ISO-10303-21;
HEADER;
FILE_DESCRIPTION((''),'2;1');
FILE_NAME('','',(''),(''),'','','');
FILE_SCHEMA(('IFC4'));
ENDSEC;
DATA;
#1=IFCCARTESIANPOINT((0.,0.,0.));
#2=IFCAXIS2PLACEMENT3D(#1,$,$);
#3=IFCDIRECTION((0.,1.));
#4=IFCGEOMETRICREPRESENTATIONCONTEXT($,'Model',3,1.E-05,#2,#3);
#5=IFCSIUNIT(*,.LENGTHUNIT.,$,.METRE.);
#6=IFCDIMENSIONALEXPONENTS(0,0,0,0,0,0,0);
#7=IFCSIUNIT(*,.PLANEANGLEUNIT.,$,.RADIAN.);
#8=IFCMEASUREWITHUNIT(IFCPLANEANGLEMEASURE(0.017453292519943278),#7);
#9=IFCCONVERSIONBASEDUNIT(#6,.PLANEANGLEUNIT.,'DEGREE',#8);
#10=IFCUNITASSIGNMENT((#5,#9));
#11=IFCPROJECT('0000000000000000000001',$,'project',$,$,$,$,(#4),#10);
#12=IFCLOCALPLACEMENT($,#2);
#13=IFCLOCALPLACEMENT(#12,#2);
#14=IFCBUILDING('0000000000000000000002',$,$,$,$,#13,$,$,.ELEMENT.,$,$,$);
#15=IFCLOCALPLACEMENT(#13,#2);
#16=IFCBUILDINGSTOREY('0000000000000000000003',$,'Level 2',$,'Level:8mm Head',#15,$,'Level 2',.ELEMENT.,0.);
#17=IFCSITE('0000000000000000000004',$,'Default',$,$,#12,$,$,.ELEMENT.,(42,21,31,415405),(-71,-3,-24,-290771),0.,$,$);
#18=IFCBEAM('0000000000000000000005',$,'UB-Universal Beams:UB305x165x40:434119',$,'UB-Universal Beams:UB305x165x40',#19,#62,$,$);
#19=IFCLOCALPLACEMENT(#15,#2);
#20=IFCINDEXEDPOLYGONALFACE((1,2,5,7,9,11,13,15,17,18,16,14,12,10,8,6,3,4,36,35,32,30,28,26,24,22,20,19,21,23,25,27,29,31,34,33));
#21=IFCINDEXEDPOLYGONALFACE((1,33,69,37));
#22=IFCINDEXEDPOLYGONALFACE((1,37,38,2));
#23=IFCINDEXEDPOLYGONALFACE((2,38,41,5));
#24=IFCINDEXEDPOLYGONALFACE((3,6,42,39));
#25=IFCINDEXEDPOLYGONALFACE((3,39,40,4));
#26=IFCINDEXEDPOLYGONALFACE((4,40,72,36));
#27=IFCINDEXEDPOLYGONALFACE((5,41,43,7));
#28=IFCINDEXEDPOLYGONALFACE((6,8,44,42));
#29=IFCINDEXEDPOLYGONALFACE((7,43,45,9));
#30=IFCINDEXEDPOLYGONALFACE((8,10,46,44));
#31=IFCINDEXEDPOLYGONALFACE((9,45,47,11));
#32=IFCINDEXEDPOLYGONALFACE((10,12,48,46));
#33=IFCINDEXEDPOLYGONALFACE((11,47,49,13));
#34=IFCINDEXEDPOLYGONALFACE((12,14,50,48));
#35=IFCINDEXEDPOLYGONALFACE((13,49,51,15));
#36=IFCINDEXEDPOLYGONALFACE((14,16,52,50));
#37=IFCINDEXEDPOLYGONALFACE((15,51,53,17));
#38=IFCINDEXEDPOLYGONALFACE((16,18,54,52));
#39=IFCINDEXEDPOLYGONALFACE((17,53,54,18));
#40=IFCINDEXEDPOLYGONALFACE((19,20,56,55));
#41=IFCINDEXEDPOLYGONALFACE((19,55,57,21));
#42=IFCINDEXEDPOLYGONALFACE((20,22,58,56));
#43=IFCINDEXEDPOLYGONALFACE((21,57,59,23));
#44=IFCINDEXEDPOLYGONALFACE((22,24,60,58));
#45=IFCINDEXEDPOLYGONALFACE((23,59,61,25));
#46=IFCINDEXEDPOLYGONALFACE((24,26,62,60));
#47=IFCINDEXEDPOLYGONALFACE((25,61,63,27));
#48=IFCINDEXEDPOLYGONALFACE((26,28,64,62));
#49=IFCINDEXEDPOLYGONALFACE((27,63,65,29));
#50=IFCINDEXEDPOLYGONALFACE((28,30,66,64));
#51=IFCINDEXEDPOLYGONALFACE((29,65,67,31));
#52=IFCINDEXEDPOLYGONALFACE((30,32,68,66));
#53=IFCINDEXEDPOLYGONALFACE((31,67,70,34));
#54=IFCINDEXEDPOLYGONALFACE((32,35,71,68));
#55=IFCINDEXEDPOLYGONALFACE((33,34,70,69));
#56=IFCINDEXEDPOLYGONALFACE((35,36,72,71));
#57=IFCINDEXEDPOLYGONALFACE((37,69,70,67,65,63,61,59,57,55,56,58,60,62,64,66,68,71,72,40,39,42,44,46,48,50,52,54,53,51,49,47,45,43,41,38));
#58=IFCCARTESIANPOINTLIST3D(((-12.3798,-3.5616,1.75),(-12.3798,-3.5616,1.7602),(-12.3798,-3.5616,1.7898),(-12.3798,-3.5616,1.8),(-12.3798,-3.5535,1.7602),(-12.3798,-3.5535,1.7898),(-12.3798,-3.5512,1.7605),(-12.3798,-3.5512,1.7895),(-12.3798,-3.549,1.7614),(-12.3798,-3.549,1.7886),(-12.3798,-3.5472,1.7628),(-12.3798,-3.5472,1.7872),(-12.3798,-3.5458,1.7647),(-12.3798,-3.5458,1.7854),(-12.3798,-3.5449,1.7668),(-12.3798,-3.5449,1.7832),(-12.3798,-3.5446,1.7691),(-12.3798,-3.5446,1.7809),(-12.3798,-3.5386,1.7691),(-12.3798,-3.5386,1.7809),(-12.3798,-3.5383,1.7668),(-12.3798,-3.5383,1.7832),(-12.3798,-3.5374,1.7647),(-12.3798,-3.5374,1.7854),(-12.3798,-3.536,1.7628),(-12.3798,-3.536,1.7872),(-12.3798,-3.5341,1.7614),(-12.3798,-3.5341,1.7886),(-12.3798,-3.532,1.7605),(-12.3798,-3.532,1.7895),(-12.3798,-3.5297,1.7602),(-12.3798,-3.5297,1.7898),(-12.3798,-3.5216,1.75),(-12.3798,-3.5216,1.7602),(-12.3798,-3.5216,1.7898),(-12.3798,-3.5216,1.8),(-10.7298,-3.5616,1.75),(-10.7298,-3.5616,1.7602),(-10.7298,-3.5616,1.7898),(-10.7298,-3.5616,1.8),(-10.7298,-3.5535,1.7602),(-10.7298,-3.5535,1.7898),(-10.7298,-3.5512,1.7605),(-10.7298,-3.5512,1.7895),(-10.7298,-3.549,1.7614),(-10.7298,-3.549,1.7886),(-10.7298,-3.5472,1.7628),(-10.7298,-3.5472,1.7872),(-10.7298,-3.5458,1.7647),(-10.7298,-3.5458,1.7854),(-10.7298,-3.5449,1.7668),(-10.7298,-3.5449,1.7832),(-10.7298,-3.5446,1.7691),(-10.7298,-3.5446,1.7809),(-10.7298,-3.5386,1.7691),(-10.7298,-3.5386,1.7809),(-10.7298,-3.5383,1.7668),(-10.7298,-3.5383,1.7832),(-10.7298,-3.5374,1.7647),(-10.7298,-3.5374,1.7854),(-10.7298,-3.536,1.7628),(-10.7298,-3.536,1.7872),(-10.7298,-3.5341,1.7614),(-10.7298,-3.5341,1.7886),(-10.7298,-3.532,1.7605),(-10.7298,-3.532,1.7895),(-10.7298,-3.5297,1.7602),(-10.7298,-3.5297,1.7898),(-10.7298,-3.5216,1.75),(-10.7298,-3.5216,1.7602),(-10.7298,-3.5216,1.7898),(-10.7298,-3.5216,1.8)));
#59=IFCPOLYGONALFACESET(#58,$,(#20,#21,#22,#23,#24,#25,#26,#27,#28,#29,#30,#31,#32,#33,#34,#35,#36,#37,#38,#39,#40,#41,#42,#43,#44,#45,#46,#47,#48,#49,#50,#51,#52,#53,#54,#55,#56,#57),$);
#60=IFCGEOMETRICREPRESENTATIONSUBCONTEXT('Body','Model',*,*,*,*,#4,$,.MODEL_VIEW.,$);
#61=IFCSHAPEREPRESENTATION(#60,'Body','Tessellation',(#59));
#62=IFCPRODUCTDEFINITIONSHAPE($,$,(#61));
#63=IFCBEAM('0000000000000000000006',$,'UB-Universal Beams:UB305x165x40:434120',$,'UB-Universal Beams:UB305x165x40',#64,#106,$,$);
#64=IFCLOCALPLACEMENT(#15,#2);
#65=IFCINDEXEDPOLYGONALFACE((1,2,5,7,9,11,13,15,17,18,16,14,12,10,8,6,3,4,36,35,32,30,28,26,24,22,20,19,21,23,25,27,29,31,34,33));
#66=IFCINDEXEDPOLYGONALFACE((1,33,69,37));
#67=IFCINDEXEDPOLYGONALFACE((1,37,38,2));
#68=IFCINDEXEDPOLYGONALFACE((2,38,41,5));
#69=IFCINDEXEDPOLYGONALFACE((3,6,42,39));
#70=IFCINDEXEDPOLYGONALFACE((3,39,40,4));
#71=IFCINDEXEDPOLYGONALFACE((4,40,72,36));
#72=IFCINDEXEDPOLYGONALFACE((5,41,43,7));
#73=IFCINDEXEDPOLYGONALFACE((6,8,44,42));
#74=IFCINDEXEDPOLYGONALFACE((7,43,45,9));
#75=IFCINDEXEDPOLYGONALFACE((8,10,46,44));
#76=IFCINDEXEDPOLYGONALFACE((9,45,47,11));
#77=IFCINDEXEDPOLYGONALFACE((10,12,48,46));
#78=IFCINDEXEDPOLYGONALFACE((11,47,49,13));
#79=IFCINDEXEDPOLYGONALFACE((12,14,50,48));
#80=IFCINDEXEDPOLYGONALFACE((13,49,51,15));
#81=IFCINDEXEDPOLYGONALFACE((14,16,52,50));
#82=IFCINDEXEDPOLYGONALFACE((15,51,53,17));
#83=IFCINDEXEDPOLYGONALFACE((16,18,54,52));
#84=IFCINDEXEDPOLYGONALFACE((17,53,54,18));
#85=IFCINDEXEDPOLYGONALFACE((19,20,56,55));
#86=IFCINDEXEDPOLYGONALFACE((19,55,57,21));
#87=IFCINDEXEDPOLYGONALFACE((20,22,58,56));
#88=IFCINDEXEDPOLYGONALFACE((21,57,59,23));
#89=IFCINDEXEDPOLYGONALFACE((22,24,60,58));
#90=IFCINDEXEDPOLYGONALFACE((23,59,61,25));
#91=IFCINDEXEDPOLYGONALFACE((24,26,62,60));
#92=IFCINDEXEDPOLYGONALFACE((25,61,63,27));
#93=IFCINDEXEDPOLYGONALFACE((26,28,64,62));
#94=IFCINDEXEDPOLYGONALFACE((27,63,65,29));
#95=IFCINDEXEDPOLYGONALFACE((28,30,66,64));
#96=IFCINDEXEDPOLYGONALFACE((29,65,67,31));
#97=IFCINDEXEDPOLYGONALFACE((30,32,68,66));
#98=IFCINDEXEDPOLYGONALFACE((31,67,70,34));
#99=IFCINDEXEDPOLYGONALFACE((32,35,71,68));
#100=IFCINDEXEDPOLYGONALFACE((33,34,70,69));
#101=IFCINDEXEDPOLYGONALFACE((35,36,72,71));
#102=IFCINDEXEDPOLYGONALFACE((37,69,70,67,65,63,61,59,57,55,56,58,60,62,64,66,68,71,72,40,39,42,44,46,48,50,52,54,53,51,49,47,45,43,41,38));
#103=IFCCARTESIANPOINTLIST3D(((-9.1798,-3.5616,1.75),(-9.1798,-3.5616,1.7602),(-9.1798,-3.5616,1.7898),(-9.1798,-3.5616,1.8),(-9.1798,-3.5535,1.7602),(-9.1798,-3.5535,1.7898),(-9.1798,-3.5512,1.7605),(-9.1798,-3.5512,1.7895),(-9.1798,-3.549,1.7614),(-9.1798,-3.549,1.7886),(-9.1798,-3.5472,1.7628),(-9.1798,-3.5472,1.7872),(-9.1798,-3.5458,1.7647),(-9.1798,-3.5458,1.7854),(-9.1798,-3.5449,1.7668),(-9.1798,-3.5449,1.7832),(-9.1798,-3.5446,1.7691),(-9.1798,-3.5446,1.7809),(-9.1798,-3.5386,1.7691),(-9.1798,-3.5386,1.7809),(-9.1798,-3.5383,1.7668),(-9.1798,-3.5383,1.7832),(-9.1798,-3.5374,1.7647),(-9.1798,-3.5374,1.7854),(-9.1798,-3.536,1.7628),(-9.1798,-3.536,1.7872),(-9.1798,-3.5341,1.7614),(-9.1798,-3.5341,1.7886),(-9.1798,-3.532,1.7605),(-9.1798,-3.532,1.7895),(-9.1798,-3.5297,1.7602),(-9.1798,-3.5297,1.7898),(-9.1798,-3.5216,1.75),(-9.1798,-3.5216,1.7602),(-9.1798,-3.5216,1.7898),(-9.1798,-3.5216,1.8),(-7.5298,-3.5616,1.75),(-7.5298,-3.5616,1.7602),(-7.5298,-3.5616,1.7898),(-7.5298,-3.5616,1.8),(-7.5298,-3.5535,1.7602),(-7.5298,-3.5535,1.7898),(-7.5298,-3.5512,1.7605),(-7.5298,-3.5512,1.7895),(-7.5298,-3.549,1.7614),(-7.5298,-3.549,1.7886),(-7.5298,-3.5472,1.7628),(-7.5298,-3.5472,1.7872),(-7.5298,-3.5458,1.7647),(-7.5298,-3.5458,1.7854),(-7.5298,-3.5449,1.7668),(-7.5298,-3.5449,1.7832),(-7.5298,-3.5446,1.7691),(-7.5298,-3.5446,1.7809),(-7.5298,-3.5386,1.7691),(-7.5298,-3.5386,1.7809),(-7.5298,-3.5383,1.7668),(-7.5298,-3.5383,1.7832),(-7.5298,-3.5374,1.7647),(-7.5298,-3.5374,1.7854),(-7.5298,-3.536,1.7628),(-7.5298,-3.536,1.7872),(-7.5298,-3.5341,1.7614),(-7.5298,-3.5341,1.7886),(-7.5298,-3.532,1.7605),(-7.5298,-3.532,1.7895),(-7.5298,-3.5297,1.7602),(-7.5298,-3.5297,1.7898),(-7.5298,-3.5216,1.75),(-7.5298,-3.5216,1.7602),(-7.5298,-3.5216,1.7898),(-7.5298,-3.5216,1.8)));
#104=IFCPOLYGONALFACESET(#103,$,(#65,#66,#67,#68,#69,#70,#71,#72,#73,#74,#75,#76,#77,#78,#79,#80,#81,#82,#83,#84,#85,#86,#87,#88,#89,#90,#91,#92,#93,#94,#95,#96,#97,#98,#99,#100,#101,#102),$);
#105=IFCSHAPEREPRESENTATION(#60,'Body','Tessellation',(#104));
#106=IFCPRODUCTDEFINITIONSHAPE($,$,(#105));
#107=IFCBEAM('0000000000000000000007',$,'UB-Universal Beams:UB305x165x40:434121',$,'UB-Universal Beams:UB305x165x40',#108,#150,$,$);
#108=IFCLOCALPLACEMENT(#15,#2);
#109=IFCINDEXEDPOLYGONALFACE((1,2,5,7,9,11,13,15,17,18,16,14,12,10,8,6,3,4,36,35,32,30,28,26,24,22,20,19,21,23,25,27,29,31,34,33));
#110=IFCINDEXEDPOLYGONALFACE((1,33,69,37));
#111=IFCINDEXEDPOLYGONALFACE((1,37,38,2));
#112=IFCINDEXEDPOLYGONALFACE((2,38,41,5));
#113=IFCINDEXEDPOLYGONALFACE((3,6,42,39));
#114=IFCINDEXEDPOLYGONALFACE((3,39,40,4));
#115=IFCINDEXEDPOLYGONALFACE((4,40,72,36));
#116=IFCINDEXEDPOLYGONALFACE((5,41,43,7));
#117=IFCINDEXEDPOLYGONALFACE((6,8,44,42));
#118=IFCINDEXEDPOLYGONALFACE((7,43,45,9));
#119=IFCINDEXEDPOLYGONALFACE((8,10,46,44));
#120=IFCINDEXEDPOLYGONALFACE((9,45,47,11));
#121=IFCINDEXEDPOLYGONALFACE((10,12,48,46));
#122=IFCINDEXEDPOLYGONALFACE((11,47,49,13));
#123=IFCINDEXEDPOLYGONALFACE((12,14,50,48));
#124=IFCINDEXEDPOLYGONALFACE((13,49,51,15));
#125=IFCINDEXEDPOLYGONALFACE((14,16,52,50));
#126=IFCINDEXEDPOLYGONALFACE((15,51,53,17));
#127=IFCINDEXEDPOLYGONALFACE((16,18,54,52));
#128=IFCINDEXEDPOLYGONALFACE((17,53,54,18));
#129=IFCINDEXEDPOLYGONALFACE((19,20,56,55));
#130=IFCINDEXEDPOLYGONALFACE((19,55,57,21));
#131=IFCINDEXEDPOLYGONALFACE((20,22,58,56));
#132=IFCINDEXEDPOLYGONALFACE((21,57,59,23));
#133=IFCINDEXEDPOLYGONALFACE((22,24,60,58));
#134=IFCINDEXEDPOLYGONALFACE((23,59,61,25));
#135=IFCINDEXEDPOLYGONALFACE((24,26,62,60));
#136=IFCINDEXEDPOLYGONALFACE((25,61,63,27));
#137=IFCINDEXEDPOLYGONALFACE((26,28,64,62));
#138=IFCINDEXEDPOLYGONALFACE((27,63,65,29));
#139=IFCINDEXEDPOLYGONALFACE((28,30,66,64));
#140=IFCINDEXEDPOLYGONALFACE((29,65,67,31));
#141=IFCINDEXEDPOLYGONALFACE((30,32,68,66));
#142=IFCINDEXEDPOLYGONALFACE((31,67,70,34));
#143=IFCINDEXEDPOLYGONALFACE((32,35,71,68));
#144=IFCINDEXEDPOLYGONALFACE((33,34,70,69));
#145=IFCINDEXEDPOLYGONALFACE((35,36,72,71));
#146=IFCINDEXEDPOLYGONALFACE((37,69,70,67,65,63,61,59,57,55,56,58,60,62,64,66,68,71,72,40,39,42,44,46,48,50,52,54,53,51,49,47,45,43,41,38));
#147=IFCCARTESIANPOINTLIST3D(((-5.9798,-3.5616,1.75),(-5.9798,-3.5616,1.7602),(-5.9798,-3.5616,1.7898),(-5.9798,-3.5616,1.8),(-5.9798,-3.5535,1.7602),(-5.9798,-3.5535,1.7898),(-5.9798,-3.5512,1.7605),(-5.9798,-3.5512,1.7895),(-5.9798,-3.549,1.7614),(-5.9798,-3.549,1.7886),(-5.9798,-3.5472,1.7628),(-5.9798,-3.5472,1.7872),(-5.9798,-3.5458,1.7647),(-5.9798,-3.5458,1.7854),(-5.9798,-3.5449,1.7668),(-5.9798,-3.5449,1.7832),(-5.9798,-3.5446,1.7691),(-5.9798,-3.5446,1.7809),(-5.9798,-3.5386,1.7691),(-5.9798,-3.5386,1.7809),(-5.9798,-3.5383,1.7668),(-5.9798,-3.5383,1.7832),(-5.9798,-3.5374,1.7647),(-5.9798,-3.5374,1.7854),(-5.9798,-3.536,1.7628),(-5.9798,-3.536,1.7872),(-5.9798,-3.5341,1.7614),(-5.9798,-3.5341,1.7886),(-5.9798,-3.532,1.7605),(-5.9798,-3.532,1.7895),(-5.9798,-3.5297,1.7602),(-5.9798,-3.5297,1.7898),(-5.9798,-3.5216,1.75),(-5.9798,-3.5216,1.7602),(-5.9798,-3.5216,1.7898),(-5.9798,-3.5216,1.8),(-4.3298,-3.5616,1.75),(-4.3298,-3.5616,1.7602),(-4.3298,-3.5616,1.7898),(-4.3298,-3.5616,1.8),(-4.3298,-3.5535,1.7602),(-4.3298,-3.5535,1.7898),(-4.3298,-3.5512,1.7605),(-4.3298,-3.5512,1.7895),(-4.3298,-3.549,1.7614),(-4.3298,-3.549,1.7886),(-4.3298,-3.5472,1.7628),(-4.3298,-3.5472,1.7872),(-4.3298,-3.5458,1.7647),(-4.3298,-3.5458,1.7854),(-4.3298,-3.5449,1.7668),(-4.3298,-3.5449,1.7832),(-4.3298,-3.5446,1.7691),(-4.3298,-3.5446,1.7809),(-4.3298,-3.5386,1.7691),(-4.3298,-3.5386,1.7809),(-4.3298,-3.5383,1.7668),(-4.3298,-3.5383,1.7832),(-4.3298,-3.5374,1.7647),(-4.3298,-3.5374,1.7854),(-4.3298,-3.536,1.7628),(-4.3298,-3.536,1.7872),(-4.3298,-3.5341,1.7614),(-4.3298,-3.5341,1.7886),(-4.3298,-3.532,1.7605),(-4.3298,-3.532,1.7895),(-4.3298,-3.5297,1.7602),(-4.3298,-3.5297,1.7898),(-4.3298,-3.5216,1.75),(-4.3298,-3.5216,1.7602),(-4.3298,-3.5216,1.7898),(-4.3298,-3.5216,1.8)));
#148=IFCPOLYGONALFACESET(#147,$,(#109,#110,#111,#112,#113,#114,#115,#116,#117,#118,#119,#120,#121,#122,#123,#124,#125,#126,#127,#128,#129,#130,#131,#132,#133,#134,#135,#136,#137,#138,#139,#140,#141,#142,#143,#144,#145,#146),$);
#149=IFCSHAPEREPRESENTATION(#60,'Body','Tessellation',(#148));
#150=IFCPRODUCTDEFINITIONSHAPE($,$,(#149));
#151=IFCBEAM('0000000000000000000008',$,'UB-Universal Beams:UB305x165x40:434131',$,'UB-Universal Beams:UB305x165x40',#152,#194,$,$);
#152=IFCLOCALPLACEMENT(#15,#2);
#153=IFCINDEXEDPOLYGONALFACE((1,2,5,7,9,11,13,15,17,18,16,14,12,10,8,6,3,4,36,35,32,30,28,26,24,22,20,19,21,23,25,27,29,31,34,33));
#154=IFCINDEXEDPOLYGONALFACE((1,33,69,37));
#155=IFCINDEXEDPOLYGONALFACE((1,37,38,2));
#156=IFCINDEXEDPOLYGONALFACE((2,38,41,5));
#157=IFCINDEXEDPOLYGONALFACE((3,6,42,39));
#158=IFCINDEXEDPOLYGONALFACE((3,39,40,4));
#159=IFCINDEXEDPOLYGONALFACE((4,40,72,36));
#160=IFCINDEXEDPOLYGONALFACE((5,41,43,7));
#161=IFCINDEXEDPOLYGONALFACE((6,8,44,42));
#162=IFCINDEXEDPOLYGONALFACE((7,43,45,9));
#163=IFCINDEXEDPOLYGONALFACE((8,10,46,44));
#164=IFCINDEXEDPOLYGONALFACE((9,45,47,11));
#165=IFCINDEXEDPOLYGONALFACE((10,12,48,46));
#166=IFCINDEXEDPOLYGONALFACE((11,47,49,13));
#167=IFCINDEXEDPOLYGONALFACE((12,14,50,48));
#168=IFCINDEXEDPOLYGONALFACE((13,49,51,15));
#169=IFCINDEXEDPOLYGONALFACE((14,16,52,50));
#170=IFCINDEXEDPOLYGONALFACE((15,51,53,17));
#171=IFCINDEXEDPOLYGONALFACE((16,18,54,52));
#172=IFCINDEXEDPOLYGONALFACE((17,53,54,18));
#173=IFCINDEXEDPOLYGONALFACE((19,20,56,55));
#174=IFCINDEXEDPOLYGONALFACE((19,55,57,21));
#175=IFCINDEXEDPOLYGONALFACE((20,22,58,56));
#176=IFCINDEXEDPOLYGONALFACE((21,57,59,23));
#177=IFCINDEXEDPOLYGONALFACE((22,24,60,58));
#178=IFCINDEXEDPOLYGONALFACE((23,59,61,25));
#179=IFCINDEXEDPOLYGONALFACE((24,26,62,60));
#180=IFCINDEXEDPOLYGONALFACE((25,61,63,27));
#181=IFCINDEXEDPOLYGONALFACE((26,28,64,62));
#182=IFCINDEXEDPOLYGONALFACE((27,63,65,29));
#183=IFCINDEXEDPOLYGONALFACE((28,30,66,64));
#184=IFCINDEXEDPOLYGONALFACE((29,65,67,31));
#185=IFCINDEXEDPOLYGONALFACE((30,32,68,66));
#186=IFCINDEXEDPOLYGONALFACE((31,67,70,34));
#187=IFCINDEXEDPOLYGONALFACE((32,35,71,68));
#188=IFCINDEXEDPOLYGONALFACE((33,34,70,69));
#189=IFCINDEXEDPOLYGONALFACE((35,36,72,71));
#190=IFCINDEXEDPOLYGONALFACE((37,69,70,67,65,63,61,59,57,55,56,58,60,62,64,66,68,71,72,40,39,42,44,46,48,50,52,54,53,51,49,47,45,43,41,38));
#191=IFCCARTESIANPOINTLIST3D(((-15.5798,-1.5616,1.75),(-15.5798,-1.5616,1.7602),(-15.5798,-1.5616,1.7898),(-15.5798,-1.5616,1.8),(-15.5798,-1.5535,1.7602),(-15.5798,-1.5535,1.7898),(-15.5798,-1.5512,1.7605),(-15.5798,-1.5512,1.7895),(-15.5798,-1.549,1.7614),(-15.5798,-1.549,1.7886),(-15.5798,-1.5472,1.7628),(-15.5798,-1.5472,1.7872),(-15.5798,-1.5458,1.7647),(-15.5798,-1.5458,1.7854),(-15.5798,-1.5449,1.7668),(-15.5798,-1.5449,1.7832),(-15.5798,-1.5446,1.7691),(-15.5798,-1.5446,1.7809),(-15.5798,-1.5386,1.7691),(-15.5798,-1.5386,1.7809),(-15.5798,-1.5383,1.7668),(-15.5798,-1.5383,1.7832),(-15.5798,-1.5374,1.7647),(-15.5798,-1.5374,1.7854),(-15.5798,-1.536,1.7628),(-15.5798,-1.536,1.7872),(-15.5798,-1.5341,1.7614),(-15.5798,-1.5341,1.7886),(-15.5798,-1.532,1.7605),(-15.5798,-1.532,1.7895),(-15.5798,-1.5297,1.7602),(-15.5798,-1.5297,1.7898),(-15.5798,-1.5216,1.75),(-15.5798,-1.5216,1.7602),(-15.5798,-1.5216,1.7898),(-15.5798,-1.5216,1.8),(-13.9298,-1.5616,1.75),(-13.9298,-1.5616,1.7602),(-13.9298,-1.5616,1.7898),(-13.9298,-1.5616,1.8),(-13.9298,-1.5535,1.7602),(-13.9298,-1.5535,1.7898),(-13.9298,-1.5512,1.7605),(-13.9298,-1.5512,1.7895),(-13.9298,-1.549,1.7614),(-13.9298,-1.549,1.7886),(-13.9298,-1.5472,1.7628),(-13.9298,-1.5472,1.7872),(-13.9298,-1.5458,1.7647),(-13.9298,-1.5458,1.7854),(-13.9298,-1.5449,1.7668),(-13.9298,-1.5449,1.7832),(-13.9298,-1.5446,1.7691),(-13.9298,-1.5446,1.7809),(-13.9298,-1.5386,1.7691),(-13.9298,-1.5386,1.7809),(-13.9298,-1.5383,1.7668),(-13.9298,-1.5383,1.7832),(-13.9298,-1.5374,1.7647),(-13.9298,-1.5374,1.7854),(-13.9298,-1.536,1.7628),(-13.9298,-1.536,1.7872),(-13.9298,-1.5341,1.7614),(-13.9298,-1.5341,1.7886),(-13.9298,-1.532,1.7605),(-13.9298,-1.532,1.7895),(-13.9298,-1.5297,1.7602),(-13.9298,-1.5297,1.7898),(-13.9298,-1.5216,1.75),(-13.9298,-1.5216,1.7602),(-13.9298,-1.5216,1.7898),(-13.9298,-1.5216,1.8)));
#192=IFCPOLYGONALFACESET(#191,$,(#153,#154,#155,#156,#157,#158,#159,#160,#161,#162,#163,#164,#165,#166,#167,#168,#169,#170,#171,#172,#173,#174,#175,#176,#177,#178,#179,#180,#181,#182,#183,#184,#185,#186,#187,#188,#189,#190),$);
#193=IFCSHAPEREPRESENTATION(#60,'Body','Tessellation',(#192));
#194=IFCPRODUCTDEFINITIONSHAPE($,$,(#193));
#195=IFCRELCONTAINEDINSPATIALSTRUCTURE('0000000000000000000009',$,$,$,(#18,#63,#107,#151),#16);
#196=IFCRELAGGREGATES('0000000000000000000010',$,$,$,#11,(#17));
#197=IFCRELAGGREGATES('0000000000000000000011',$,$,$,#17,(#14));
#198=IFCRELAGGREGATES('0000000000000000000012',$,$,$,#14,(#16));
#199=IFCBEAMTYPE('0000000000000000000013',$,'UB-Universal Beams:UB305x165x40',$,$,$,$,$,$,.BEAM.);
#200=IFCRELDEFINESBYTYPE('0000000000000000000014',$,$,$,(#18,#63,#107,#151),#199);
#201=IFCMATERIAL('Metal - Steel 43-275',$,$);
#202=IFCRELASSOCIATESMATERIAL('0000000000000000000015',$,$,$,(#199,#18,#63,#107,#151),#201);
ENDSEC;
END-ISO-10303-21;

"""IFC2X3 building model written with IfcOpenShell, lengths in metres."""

from ifc_helpers import new_model, entity, si_unit, converted_unit, direction, frame, frame_2d, origin, place, context, subcontext, project, spatial, i_section, extrude, material, type_object, element, save


model = new_model("IFC2X3")

# Units and contexts
model_context = context("Model", 3, precision=1e-05, world=origin(), true_north=direction((0.0, 1.0)))
body_context = subcontext(model_context, "Body", "Model", "MODEL_VIEW")
ifc_project = project(units=[si_unit("LENGTHUNIT", "METRE"), converted_unit("PLANEANGLEUNIT", "DEGREE", entity("IfcPlaneAngleMeasure", 0.017453292519943278), si_unit("PLANEANGLEUNIT", "RADIAN"), dimensions=[0, 0, 0, 0, 0, 0, 0])], contexts=[model_context])

# Site, building, storey
site_placement = place(None, origin())
site = spatial("IfcSite", under=ifc_project, at=site_placement, Name="Default", CompositionType="ELEMENT", RefLatitude=(42, 21, 31, 415405), RefLongitude=(-71, -3, -24, -290771), RefElevation=0.0)
building_placement = place(site_placement, origin())
building = spatial("IfcBuilding", under=site, at=building_placement, CompositionType="ELEMENT")
storey_placement = place(building_placement, origin())
storey = spatial("IfcBuildingStorey", under=building, at=storey_placement, Name="Level 2", ObjectType="Level:8mm Head", LongName="Level 2", CompositionType="ELEMENT", Elevation=0.0)

# Shared definitions
ifc_material = material(Name="Metal - Steel 43-275")

# Beams
beam_type = type_object("IfcBeamType", Name="UB-Universal Beams:UB305x165x40", PredefinedType="BEAM", material=ifc_material)
for number, where, name in (
    (1, (-12.3798, -3.5416, 1.8), "UB-Universal Beams:UB305x165x40:434119"),
):
    element("IfcBeam", number, at=place(storey_placement, frame(where)), inside=storey, type_object=beam_type, material=ifc_material, Name=name, ObjectType="UB-Universal Beams:UB305x165x40", context=body_context, shape_type="SweptSolid", body=[
        extrude(i_section(OverallWidth=0.04, OverallDepth=0.05, WebThickness=0.006, FlangeThickness=0.0102, FilletRadius=0.0089, at=frame_2d((0.0, 0.0), x_axis=(0.0, 1.0))), frame((0.0, 0.0, -0.025), z_axis=(1.0, 0.0, 0.0), x_axis=(0.0, 0.0, -1.0)), (0.0, 0.0, 1.0), 1.65),
    ])
for number, where, name in (
    (2, (-9.1798, -3.5416, 1.8), "UB-Universal Beams:UB305x165x40:434120"),
    (3, (-5.9798, -3.5416, 1.8), "UB-Universal Beams:UB305x165x40:434121"),
):
    element("IfcBeam", number, at=place(storey_placement, frame(where)), inside=storey, type_object=beam_type, material=ifc_material, Name=name, ObjectType="UB-Universal Beams:UB305x165x40", context=body_context, shape_type="SweptSolid", body=[
        extrude(i_section(OverallWidth=0.04, OverallDepth=0.05, WebThickness=0.006, FlangeThickness=0.0102, FilletRadius=0.0089, at=frame_2d((0.0, 0.0), x_axis=(0.0, 1.0))), frame((0.0, 0.0, -0.025), z_axis=(1.0, 0.0, 0.0), x_axis=(0.0, 0.0, -1.0)), (0.0, 0.0, 1.0), 1.65),
    ])
for number, where, name in (
    (4, (-15.5798, -1.5416, 1.8), "UB-Universal Beams:UB305x165x40:434131"),
):
    element("IfcBeam", number, at=place(storey_placement, frame(where)), inside=storey, type_object=beam_type, material=ifc_material, Name=name, ObjectType="UB-Universal Beams:UB305x165x40", context=body_context, shape_type="SweptSolid", body=[
        extrude(i_section(OverallWidth=0.04, OverallDepth=0.05, WebThickness=0.006, FlangeThickness=0.0102, FilletRadius=0.0089, at=frame_2d((0.0, 0.0), x_axis=(0.0, 1.0))), frame((0.0, 0.0, -0.025), z_axis=(1.0, 0.0, 0.0), x_axis=(0.0, 0.0, -1.0)), (0.0, 0.0, 1.0), 1.65),
    ])

save(model, "model.ifc")
